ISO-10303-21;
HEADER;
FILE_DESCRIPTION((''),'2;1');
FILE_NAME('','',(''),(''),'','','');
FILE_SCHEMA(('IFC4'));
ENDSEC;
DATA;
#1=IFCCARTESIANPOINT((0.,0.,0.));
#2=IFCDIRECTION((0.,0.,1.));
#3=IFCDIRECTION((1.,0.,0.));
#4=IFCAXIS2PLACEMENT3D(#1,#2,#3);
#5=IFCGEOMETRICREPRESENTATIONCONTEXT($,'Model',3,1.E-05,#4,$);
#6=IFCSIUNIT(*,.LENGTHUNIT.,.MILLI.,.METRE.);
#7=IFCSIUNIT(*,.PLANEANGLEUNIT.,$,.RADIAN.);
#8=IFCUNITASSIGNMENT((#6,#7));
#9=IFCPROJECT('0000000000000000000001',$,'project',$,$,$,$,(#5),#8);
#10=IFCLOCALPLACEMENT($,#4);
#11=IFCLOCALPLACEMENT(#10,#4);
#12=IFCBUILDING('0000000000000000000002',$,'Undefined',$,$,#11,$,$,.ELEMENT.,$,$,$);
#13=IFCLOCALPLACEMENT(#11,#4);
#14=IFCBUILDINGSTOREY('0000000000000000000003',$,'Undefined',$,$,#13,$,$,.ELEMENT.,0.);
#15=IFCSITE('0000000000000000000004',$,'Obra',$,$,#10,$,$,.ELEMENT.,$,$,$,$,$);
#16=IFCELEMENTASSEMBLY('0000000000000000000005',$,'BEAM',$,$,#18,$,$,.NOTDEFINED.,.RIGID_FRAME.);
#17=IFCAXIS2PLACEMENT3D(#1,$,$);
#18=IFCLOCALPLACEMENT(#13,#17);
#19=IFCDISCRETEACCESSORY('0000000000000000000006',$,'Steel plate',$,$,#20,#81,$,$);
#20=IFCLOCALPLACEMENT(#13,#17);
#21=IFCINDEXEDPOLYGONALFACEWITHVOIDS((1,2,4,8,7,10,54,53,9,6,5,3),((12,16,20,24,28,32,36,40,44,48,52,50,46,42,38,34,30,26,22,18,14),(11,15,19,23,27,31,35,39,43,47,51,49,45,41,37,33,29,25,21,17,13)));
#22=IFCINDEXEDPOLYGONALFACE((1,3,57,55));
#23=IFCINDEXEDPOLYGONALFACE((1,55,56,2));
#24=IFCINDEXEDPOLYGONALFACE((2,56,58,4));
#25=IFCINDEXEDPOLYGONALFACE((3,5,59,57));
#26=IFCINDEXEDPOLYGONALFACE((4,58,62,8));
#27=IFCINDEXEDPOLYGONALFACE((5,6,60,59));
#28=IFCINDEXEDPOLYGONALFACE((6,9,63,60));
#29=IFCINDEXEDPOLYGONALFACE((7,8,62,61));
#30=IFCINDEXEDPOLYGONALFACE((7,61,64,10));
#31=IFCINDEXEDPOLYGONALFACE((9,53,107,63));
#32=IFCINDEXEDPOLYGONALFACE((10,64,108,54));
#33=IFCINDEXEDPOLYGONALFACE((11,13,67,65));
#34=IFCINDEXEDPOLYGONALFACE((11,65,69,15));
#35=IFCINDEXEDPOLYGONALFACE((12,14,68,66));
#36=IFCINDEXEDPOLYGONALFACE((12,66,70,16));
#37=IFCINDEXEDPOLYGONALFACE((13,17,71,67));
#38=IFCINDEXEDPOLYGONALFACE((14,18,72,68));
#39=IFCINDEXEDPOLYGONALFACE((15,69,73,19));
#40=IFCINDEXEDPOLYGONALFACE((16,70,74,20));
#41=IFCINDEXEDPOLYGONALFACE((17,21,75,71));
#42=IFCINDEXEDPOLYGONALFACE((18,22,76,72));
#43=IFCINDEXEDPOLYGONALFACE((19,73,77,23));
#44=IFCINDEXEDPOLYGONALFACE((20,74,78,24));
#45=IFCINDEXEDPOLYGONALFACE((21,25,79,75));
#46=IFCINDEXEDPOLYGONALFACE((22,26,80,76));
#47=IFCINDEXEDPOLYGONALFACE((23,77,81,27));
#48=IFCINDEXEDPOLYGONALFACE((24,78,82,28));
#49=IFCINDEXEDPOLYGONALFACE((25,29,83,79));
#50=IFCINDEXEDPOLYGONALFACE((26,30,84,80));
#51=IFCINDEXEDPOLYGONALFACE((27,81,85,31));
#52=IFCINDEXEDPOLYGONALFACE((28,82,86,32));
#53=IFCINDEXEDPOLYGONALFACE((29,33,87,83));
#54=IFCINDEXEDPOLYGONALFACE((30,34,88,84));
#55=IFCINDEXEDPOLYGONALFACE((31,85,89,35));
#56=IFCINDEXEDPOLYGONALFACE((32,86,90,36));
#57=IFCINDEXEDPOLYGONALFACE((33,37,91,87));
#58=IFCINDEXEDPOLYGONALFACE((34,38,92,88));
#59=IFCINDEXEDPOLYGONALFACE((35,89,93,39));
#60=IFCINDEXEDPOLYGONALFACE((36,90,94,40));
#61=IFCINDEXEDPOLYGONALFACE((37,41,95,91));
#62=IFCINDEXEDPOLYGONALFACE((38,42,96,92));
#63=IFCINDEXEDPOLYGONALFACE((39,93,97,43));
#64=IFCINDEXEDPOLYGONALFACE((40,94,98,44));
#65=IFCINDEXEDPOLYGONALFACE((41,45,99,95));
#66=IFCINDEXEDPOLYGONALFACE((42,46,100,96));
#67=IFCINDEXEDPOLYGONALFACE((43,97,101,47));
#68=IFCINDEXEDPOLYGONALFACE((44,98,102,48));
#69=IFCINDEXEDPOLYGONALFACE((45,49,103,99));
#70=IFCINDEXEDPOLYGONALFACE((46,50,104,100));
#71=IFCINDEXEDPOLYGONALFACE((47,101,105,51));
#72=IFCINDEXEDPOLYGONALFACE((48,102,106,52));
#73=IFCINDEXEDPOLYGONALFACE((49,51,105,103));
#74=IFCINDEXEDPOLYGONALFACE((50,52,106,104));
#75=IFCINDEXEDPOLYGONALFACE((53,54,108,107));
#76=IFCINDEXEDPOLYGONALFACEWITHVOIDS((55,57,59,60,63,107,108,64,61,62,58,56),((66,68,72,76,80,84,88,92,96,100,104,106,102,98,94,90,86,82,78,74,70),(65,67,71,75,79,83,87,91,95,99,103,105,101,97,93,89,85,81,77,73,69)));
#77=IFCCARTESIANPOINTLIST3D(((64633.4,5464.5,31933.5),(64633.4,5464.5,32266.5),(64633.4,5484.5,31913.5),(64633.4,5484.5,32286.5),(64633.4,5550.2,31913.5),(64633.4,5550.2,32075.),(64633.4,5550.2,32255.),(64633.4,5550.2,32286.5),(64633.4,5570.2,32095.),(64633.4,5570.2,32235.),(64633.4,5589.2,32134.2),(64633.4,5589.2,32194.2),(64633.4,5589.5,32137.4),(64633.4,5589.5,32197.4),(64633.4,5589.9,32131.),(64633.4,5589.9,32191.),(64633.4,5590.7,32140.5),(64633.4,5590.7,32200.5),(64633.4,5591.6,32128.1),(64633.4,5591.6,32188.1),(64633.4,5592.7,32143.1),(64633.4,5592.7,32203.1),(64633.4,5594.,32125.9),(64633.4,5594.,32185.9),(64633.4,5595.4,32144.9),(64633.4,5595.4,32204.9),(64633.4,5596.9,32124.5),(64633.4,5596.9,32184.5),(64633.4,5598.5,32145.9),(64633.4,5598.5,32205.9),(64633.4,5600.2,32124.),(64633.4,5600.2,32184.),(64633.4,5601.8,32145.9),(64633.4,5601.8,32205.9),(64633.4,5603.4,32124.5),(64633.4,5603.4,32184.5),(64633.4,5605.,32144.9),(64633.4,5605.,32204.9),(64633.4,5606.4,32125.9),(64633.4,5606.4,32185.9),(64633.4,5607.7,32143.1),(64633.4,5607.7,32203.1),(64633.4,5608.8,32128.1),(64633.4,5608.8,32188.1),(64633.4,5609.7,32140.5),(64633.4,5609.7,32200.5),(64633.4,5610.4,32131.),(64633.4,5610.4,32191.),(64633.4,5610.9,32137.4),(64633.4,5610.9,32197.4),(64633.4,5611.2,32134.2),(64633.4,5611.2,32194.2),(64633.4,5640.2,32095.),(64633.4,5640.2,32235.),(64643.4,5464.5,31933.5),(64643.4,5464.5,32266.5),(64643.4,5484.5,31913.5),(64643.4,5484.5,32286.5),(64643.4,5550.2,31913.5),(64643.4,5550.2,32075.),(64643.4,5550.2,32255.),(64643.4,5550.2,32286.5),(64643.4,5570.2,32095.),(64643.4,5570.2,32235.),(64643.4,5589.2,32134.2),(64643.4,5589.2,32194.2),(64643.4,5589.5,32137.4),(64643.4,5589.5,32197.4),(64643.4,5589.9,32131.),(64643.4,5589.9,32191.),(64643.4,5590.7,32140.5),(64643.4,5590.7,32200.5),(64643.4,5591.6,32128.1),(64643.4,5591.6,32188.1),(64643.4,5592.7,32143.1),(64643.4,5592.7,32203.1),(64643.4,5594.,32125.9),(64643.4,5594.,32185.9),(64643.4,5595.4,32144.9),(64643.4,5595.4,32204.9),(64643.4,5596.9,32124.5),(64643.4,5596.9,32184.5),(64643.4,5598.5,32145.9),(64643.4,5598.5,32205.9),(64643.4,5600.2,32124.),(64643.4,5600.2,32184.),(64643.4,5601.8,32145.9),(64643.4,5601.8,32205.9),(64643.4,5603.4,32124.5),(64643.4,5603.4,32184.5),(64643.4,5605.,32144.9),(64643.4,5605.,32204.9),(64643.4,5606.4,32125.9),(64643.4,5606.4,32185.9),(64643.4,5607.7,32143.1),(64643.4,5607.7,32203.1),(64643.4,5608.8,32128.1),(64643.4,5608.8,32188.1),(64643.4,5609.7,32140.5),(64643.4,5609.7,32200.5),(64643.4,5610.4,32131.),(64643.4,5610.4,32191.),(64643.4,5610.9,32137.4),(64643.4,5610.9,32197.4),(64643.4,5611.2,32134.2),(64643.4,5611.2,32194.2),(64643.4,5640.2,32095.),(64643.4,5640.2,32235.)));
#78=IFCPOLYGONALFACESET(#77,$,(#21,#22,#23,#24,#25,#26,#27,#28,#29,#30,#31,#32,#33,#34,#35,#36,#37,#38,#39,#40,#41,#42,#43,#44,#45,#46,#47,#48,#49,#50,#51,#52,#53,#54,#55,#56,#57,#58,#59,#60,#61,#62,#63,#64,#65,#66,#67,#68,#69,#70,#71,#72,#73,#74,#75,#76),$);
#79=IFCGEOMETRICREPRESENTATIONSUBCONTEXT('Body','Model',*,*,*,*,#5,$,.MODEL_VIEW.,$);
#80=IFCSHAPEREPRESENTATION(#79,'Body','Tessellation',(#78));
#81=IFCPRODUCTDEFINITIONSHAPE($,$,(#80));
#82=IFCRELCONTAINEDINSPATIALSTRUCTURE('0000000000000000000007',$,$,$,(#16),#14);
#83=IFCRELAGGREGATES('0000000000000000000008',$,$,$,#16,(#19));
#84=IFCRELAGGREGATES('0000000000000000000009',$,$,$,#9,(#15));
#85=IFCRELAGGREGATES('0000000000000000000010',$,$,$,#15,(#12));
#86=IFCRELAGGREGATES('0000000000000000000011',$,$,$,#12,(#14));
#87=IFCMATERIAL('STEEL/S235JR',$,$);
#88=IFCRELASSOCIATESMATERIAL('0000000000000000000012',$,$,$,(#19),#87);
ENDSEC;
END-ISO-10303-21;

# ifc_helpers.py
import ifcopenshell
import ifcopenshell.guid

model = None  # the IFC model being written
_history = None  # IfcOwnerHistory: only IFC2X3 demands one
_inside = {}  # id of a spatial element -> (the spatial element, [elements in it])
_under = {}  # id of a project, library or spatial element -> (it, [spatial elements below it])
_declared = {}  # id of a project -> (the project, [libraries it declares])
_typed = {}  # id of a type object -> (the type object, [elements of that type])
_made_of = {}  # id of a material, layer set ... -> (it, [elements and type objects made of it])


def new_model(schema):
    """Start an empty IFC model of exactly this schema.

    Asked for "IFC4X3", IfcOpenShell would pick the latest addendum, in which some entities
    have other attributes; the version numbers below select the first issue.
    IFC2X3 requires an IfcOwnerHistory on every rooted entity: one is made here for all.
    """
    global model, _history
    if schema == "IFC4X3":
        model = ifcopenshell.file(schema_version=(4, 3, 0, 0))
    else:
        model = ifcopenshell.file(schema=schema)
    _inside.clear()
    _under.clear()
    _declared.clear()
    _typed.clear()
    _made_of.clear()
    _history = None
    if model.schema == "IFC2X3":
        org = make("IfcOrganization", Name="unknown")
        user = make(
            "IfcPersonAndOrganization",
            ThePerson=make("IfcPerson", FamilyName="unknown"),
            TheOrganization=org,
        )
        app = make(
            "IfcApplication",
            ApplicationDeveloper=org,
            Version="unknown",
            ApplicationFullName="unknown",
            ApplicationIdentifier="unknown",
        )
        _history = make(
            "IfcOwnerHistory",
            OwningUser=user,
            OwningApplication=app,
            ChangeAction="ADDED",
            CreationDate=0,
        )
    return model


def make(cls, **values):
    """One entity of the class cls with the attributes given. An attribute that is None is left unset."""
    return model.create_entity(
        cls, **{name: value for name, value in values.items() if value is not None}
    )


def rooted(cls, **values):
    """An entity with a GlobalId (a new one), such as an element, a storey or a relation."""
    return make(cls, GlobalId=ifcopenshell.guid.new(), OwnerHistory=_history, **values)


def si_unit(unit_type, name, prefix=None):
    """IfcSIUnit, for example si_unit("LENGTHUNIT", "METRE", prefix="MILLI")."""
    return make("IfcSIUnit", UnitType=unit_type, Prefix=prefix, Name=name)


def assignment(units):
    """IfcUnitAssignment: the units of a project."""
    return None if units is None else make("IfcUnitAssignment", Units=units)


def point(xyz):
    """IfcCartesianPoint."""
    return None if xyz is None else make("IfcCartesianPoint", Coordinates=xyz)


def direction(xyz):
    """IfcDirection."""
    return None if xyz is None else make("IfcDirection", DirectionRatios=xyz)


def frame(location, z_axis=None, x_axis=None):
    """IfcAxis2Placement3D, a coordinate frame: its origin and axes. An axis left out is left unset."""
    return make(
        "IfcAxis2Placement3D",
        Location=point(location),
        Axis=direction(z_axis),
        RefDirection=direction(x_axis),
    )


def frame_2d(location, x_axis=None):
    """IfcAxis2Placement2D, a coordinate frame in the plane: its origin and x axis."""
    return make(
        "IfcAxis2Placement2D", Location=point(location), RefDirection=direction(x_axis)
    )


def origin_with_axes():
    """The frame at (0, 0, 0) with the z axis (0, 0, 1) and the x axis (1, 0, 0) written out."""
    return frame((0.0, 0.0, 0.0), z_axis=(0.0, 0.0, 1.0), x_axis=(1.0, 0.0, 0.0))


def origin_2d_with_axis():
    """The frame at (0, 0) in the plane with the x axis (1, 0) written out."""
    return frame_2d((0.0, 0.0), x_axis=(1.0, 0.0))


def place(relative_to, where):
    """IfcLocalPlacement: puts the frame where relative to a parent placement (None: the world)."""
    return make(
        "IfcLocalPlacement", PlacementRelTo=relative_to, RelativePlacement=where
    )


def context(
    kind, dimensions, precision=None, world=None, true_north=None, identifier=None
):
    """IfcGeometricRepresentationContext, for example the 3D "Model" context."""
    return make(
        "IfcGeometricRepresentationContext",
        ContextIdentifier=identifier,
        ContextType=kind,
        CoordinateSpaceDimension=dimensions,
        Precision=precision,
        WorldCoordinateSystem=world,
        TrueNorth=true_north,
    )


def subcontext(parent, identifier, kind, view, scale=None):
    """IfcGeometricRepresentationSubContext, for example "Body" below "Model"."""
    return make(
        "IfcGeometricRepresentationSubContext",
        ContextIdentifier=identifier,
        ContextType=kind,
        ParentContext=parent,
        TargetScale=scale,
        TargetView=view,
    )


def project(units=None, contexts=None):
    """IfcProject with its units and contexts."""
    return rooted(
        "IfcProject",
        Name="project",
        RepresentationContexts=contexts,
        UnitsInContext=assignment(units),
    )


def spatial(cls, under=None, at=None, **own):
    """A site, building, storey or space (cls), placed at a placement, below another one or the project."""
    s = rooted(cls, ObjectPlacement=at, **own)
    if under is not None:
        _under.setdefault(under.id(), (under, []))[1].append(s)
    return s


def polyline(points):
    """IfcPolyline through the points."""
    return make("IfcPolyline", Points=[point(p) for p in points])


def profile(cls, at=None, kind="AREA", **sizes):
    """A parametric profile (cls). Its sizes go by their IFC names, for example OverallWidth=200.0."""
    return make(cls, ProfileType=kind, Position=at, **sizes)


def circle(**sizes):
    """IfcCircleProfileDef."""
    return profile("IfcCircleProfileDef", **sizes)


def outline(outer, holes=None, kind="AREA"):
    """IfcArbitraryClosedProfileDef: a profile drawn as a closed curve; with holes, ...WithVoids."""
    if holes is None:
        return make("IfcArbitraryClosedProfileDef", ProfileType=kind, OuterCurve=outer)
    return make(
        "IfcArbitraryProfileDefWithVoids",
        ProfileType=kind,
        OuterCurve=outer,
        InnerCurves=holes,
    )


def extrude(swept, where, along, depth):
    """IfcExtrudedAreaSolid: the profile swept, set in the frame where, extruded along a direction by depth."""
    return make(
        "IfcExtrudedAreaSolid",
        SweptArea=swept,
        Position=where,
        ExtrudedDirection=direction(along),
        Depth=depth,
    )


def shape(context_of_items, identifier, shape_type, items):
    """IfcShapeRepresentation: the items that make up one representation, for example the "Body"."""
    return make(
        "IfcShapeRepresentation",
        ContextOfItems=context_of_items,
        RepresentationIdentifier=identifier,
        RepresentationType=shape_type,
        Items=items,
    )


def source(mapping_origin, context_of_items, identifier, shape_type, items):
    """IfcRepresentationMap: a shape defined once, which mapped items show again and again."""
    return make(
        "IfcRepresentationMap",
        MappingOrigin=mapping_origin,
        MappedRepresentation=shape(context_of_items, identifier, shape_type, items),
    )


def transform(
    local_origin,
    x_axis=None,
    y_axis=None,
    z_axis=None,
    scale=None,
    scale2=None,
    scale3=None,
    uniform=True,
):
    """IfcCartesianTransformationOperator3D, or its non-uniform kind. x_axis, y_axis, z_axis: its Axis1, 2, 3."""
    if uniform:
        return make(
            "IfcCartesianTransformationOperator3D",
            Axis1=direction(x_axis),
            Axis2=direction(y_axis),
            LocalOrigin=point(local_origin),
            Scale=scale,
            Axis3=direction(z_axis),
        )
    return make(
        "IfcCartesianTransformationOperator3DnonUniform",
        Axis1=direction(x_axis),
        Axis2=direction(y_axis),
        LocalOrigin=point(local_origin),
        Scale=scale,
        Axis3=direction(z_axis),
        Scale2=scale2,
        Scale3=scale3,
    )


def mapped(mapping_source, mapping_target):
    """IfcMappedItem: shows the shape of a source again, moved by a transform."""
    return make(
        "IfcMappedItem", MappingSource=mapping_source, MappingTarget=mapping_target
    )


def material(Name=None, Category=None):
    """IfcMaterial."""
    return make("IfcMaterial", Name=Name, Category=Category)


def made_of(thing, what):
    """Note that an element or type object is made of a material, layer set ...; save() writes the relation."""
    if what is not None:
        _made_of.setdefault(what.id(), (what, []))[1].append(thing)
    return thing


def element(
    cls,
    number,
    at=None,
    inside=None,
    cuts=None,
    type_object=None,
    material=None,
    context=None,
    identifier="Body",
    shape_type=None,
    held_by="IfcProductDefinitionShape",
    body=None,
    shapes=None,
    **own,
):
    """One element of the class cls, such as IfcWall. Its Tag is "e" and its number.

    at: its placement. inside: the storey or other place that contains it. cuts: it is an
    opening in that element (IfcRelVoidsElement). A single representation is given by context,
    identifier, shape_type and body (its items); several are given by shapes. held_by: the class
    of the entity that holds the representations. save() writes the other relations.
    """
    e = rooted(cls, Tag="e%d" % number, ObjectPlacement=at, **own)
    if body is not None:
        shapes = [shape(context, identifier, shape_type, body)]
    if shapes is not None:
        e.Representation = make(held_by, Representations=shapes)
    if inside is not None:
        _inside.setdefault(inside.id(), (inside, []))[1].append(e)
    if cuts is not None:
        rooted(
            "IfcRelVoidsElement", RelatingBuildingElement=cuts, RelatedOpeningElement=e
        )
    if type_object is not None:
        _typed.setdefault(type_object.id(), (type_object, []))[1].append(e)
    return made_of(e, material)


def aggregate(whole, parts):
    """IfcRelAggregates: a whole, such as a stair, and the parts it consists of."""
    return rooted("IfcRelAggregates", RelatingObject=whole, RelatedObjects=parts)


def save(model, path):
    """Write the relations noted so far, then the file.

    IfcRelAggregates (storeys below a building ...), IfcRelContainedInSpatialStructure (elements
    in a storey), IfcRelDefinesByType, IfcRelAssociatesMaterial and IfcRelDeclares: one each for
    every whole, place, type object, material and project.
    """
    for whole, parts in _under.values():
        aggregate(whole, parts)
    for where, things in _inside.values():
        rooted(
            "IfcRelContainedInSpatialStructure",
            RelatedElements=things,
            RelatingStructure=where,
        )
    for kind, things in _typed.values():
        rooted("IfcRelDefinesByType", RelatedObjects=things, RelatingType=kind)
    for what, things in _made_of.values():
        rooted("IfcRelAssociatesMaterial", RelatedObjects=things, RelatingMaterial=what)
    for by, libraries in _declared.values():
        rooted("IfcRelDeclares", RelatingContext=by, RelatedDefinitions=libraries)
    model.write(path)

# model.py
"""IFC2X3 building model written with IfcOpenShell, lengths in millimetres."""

from ifc_helpers import new_model, si_unit, frame, origin_with_axes, origin_2d_with_axis, place, context, subcontext, project, spatial, polyline, circle, outline, extrude, source, transform, mapped, material, element, aggregate, save


model = new_model("IFC2X3")

# Units and contexts
model_context = context("Model", 3, precision=1e-05, world=origin_with_axes())
body_context = subcontext(model_context, "Body", "Model", "MODEL_VIEW")
ifc_project = project(units=[si_unit("LENGTHUNIT", "METRE", prefix="MILLI"), si_unit("PLANEANGLEUNIT", "RADIAN")], contexts=[model_context])

# Site, building, storey
site_placement = place(None, origin_with_axes())
site = spatial("IfcSite", under=ifc_project, at=site_placement, Name="Obra", CompositionType="ELEMENT")
building_placement = place(site_placement, origin_with_axes())
building = spatial("IfcBuilding", under=site, at=building_placement, Name="Undefined", CompositionType="ELEMENT")
storey_placement = place(building_placement, origin_with_axes())
storey = spatial("IfcBuildingStorey", under=building, at=storey_placement, Name="Undefined", CompositionType="ELEMENT", Elevation=0.0)

# Shared definitions
ifc_material_1 = material(Name="STEEL/S235JR")

# Element assembly, discrete accessory, opening
assembly_1_placement = place(storey_placement, origin_with_axes())
assembly_1 = element("IfcElementAssembly", 1, at=assembly_1_placement, inside=storey, Name="BEAM", AssemblyPlace="NOTDEFINED", PredefinedType="RIGID_FRAME")
shared_shape_1 = source(origin_with_axes(), body_context, "Body", "SweptSolid", [
    extrude(circle(Radius=11.0, at=origin_2d_with_axis()), frame((0.0, -13.4, 0.0), z_axis=(0.0, 1.0, 0.0), x_axis=(1.0, 0.0, 0.0)), (0.0, 0.0, 1.0), 10.2),
])
discrete_accessory_1_placement = place(assembly_1_placement, frame((64638.4, 5464.5, 31933.5), z_axis=(1.0, 0.0, 0.0), x_axis=(0.0, 0.707107, -0.707107)))
discrete_accessory_1 = element("IfcDiscreteAccessory", 2, at=discrete_accessory_1_placement, material=ifc_material_1, Name="Steel plate", context=body_context, shape_type="SweptSolid", body=[
    extrude(outline(polyline([(0.0, 0.0), (28.3, 0.0), (74.7, 46.5), (-39.5, 160.7), (-39.5, 188.9), (10.0, 238.4), (-89.0, 337.4), (-138.5, 287.9), (-166.7, 287.9), (-189.0, 310.2), (-235.5, 263.8), (-235.5, 235.5), (0.0, 0.0)])), frame((0.0, 0.0, -5.0), z_axis=(0.0, 0.0, 1.0), x_axis=(1.0, 0.0, 0.0)), (0.0, 0.0, 1.0), 10.0),
])
opening_1_placement = place(assembly_1_placement, frame((64630.1, 5560.2, 32235.0), z_axis=(0.0, 1.0, 0.0), x_axis=(0.0, 0.0, -1.0)))
element("IfcOpeningElement", 3, at=opening_1_placement, cuts=discrete_accessory_1, ObjectType="Opening", context=body_context, shape_type="MappedRepresentation", body=[
    mapped(shared_shape_1, transform((40.0, 0.0, 40.0))),
    mapped(shared_shape_1, transform((100.0, 0.0, 40.0))),
])
aggregate(assembly_1, [discrete_accessory_1])

save(model, "model.ifc")
